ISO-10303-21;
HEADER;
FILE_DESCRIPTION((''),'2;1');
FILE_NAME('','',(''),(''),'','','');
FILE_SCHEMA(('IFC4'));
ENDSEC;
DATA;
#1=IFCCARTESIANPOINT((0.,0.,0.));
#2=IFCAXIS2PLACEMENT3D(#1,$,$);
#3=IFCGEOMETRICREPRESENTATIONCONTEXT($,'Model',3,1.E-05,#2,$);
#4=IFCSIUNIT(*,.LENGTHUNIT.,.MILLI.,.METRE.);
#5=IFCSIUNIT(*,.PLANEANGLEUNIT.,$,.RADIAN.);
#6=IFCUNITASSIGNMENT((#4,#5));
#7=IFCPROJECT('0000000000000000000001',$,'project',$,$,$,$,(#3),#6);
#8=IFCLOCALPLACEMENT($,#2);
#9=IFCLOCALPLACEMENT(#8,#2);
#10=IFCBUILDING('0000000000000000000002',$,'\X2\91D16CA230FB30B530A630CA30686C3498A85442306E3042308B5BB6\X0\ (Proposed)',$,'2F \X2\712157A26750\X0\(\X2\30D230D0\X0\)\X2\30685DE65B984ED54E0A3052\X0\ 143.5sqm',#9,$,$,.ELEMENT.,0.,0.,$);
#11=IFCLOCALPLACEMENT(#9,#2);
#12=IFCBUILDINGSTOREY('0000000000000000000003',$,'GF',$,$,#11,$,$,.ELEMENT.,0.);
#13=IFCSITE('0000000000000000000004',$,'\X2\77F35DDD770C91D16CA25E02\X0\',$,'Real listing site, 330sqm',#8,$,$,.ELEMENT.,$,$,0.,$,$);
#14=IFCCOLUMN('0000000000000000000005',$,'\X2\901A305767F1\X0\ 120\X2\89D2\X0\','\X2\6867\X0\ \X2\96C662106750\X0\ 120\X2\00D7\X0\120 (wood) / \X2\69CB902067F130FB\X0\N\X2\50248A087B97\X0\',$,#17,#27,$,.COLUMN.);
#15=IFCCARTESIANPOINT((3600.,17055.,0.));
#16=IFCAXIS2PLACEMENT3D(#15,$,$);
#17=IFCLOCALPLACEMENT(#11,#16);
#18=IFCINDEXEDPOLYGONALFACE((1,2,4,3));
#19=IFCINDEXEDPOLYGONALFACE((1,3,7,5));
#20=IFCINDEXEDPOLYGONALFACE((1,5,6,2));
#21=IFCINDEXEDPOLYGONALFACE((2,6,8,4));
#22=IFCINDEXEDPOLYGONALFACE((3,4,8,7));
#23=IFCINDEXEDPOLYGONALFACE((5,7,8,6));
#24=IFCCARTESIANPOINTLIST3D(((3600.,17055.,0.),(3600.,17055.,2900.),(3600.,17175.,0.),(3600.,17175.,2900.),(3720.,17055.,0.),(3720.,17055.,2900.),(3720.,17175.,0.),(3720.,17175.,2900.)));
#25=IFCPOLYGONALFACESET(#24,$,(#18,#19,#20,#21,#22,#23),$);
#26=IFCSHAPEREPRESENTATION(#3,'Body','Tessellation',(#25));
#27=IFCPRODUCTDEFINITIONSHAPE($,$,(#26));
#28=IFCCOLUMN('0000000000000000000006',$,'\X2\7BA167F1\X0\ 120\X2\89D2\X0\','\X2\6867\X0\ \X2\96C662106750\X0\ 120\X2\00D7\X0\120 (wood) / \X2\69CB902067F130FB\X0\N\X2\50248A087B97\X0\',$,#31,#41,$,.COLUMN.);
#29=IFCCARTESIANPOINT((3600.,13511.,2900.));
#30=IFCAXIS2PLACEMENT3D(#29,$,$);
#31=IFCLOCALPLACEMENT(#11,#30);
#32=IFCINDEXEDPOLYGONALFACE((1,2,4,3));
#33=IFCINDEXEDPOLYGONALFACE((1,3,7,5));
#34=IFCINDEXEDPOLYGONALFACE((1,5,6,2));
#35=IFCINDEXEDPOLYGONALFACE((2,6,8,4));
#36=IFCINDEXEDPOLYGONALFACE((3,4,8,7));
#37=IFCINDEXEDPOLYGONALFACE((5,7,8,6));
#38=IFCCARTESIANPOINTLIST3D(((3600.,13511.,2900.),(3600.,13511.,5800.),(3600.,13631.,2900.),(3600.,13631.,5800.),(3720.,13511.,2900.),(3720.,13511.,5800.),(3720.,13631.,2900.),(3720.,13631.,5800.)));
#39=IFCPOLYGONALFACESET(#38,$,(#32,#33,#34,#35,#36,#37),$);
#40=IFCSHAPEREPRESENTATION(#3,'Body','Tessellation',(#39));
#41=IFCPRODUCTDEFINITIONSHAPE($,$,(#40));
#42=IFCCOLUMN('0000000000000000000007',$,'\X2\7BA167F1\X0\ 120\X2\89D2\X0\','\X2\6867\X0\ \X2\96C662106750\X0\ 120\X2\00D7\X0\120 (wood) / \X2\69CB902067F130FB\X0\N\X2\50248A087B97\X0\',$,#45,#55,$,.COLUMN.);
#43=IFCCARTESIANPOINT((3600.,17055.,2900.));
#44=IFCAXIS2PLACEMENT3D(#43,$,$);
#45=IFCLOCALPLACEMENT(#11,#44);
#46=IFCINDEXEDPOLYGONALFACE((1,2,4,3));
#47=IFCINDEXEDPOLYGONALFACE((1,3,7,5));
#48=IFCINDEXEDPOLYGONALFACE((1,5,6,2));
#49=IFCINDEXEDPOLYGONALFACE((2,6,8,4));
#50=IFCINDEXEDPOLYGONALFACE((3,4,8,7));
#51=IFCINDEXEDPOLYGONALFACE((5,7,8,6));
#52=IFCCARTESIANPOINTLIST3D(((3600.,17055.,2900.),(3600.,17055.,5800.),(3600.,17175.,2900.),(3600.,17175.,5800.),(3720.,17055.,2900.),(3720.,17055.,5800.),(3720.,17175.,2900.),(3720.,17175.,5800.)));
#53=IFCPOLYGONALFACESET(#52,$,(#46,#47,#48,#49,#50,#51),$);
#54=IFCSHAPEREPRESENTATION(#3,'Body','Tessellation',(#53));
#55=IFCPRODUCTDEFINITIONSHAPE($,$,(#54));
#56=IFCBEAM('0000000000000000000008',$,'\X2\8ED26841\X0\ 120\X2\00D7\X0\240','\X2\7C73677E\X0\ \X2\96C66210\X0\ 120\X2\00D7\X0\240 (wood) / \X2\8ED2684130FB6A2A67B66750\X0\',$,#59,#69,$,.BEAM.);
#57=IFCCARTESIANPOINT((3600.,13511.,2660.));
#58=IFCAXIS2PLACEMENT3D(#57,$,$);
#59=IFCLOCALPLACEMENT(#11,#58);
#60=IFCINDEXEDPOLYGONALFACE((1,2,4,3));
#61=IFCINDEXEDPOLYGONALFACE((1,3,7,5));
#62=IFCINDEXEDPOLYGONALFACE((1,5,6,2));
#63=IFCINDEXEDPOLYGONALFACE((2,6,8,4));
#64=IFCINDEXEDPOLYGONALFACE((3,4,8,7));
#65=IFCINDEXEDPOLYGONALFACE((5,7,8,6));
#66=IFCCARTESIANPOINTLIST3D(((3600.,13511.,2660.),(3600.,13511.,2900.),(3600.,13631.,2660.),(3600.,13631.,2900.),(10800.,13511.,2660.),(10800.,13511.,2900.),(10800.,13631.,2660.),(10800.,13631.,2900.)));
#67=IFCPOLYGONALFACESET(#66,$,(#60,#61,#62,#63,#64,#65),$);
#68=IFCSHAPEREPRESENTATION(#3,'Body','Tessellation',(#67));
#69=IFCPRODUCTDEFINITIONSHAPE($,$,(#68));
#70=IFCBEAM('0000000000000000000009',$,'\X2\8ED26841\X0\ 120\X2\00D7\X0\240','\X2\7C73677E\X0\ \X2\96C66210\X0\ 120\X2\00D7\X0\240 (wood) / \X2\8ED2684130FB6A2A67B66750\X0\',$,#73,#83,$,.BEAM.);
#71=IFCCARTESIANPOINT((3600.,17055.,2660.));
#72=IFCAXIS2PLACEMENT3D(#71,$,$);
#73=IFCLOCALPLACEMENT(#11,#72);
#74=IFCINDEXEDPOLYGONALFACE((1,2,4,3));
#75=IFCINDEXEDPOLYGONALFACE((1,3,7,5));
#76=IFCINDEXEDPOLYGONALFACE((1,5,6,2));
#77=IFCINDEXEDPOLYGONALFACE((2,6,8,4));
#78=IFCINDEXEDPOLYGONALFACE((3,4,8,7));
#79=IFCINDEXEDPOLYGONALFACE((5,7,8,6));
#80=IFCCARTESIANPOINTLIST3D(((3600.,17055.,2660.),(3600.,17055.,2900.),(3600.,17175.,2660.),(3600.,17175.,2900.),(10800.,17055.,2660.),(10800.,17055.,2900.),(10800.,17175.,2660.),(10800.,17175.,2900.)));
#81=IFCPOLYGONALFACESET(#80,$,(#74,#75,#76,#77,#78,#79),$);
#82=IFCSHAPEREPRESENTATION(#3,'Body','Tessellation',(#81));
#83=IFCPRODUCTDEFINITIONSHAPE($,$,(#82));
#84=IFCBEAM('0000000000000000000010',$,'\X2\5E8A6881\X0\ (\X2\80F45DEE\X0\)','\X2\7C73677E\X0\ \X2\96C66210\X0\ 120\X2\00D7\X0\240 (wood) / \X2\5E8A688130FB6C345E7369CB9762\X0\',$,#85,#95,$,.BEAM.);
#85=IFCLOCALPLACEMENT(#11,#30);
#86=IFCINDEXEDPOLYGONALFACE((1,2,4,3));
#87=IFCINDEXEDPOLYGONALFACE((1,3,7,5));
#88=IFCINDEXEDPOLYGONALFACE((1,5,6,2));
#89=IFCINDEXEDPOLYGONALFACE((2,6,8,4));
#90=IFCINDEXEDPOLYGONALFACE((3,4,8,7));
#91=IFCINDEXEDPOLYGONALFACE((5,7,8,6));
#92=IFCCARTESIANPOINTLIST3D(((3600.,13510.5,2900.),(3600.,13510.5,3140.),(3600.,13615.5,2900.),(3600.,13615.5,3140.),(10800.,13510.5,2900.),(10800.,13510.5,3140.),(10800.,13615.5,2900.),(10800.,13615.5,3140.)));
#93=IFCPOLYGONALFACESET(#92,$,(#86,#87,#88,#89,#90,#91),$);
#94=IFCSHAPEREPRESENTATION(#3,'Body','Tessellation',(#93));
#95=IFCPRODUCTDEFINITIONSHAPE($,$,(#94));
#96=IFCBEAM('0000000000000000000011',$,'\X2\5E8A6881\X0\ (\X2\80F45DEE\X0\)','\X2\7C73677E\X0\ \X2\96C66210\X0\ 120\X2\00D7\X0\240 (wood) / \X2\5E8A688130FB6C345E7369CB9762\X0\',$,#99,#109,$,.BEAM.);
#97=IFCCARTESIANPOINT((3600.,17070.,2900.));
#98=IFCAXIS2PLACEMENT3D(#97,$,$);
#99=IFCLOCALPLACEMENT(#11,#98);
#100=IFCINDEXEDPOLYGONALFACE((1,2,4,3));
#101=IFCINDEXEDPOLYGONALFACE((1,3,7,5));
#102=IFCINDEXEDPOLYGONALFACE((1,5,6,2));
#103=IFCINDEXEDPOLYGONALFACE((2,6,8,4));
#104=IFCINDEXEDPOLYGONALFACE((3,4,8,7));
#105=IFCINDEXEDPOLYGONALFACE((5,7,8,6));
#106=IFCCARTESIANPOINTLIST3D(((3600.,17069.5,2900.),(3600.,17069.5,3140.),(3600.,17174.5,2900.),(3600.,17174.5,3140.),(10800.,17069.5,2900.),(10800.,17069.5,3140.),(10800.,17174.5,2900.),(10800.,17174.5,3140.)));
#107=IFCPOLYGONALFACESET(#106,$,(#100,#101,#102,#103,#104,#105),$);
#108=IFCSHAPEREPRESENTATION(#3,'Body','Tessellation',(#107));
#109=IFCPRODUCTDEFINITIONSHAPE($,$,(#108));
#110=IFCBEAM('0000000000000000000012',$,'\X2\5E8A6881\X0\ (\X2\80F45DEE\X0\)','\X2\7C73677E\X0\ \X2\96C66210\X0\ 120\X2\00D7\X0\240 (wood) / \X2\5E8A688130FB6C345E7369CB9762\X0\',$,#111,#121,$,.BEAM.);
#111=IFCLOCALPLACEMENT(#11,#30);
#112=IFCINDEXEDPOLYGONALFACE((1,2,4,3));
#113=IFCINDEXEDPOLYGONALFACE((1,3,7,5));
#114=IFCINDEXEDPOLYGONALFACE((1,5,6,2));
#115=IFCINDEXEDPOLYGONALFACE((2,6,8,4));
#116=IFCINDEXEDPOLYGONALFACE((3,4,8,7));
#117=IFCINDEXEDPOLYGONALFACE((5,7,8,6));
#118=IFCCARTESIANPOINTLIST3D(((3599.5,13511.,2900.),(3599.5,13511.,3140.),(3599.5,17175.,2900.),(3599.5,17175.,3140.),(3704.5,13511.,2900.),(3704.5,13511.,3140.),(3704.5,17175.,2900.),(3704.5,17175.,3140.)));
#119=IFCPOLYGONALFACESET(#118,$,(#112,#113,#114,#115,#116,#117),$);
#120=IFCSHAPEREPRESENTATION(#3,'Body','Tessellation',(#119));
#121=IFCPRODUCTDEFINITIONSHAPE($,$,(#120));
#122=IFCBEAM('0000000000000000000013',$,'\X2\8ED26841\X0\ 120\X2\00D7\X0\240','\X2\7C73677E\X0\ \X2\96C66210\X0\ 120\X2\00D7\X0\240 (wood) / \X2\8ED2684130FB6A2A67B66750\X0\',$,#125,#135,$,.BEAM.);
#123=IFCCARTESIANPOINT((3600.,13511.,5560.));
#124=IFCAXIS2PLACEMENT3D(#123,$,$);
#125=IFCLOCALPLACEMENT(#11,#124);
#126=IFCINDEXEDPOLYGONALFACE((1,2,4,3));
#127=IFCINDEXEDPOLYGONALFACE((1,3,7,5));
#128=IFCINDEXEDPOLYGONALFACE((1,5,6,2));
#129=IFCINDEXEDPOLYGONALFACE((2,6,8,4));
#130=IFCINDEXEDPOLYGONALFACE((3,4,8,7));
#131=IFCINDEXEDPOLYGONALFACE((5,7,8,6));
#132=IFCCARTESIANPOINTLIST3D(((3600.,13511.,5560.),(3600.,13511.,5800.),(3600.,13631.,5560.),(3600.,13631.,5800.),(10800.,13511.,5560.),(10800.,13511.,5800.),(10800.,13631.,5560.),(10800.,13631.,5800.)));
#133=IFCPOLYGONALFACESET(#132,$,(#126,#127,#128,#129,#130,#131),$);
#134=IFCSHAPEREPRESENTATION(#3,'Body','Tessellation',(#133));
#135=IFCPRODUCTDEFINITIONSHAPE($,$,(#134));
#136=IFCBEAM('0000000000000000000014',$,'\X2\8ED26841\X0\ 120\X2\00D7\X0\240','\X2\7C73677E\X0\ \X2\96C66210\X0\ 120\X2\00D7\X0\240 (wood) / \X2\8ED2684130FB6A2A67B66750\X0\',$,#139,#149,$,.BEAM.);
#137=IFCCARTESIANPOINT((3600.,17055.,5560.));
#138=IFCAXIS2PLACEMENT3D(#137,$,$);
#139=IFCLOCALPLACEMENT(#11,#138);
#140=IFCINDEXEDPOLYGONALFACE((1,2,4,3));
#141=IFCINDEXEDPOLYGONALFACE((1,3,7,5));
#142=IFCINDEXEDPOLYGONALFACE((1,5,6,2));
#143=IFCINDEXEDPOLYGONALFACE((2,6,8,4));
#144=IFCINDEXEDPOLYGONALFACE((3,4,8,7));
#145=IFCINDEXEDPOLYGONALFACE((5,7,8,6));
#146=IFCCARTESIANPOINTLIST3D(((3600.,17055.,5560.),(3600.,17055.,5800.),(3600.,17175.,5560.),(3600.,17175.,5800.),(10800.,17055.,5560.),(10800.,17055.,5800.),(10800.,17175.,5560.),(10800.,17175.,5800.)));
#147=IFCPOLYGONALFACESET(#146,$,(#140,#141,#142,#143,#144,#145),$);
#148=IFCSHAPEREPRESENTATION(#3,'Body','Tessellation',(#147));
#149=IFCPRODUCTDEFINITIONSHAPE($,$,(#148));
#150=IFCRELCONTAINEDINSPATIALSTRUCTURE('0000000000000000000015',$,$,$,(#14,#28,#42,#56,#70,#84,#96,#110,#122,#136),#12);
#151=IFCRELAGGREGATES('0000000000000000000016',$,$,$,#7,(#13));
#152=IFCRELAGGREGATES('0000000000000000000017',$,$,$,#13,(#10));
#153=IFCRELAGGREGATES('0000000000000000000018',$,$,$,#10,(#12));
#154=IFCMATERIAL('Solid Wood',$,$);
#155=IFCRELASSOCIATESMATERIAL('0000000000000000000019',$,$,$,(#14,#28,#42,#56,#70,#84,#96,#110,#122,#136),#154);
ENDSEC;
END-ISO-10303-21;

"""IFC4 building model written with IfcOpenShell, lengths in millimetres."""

from ifc_helpers import new_model, si_unit, frame, frame_2d, origin, place, context, project, spatial, rectangle, extrude, material, element, save


model = new_model("IFC4")

# Units and contexts
model_context = context("Model", 3, precision=1e-05, world=origin())
ifc_project = project(units=[si_unit("LENGTHUNIT", "METRE", prefix="MILLI"), si_unit("PLANEANGLEUNIT", "RADIAN")], contexts=[model_context])

# Site, building, storey
site_placement = place(None, origin())
site = spatial("IfcSite", under=ifc_project, at=site_placement, Name="石川県金沢市", ObjectType="Real listing site, 330sqm", CompositionType="ELEMENT", RefElevation=0.0)
building_placement = place(site_placement, origin())
building = spatial("IfcBuilding", under=site, at=building_placement, Name="金沢・サウナと水風呂のある家 (Proposed)", ObjectType="2F 無垢材(ヒバ)と左官仕上げ 143.5sqm", CompositionType="ELEMENT", ElevationOfRefHeight=0.0, ElevationOfTerrain=0.0)
storey_placement = place(building_placement, origin())
storey = spatial("IfcBuildingStorey", under=building, at=storey_placement, Name="GF", CompositionType="ELEMENT", Elevation=0.0)

# Columns
ifc_material_1 = material(Name="Solid Wood")
column_1_placement = place(storey_placement, frame((3600.0, 17055.0, 0.0)))
element("IfcColumn", 1, at=column_1_placement, inside=storey, material=ifc_material_1, Name="通し柱 120角", Description="桧 集成材 120×120 (wood) / 構造柱・N値計算", PredefinedType="COLUMN", context=model_context, shape_type="SweptSolid", body=[
    extrude(rectangle(XDim=120.0, YDim=120.0, at=frame_2d((60.0, 60.0))), frame((3600.0, 17055.0, 0.0)), (0.0, 0.0, 1.0), 2900.0),
])
column_2_placement = place(storey_placement, frame((3600.0, 13511.0, 2900.0)))
element("IfcColumn", 2, at=column_2_placement, inside=storey, material=ifc_material_1, Name="管柱 120角", Description="桧 集成材 120×120 (wood) / 構造柱・N値計算", PredefinedType="COLUMN", context=model_context, shape_type="SweptSolid", body=[
    extrude(rectangle(XDim=120.0, YDim=120.0, at=frame_2d((60.0, 60.0))), frame((3600.0, 13511.0, 2900.0)), (0.0, 0.0, 1.0), 2900.0),
])
column_3_placement = place(storey_placement, frame((3600.0, 17055.0, 2900.0)))
element("IfcColumn", 3, at=column_3_placement, inside=storey, material=ifc_material_1, Name="管柱 120角", Description="桧 集成材 120×120 (wood) / 構造柱・N値計算", PredefinedType="COLUMN", context=model_context, shape_type="SweptSolid", body=[
    extrude(rectangle(XDim=120.0, YDim=120.0, at=frame_2d((60.0, 60.0))), frame((3600.0, 17055.0, 2900.0)), (0.0, 0.0, 1.0), 2900.0),
])

# Beams
beam_1_placement = place(storey_placement, frame((3600.0, 13511.0, 2660.0)))
element("IfcBeam", 4, at=beam_1_placement, inside=storey, material=ifc_material_1, Name="軒桁 120×240", Description="米松 集成 120×240 (wood) / 軒桁・横架材", PredefinedType="BEAM", context=model_context, shape_type="SweptSolid", body=[
    extrude(rectangle(XDim=7200.0, YDim=120.0, at=frame_2d((3600.0, 60.0))), frame((3600.0, 13511.0, 2660.0)), (0.0, 0.0, 1.0), 240.0),
])
beam_2_placement = place(storey_placement, frame((3600.0, 17055.0, 2660.0)))
element("IfcBeam", 5, at=beam_2_placement, inside=storey, material=ifc_material_1, Name="軒桁 120×240", Description="米松 集成 120×240 (wood) / 軒桁・横架材", PredefinedType="BEAM", context=model_context, shape_type="SweptSolid", body=[
    extrude(rectangle(XDim=7200.0, YDim=120.0, at=frame_2d((3600.0, 60.0))), frame((3600.0, 17055.0, 2660.0)), (0.0, 0.0, 1.0), 240.0),
])
beam_3_placement = place(storey_placement, frame((3600.0, 13511.0, 2900.0)))
element("IfcBeam", 6, at=beam_3_placement, inside=storey, material=ifc_material_1, Name="床梁 (胴差)", Description="米松 集成 120×240 (wood) / 床梁・水平構面", PredefinedType="BEAM", context=model_context, shape_type="SweptSolid", body=[
    extrude(rectangle(XDim=7200.0, YDim=105.0, at=frame_2d((3600.0, 52.0))), frame((3600.0, 13511.0, 2900.0)), (0.0, 0.0, 1.0), 240.0),
])
beam_4_placement = place(storey_placement, frame((3600.0, 17070.0, 2900.0)))
element("IfcBeam", 7, at=beam_4_placement, inside=storey, material=ifc_material_1, Name="床梁 (胴差)", Description="米松 集成 120×240 (wood) / 床梁・水平構面", PredefinedType="BEAM", context=model_context, shape_type="SweptSolid", body=[
    extrude(rectangle(XDim=7200.0, YDim=105.0, at=frame_2d((3600.0, 52.0))), frame((3600.0, 17070.0, 2900.0)), (0.0, 0.0, 1.0), 240.0),
])
beam_5_placement = place(storey_placement, frame((3600.0, 13511.0, 2900.0)))
element("IfcBeam", 8, at=beam_5_placement, inside=storey, material=ifc_material_1, Name="床梁 (胴差)", Description="米松 集成 120×240 (wood) / 床梁・水平構面", PredefinedType="BEAM", context=model_context, shape_type="SweptSolid", body=[
    extrude(rectangle(XDim=105.0, YDim=3664.0, at=frame_2d((52.0, 1832.0))), frame((3600.0, 13511.0, 2900.0)), (0.0, 0.0, 1.0), 240.0),
])
beam_6_placement = place(storey_placement, frame((3600.0, 13511.0, 5560.0)))
element("IfcBeam", 9, at=beam_6_placement, inside=storey, material=ifc_material_1, Name="軒桁 120×240", Description="米松 集成 120×240 (wood) / 軒桁・横架材", PredefinedType="BEAM", context=model_context, shape_type="SweptSolid", body=[
    extrude(rectangle(XDim=7200.0, YDim=120.0, at=frame_2d((3600.0, 60.0))), frame((3600.0, 13511.0, 5560.0)), (0.0, 0.0, 1.0), 240.0),
])
beam_7_placement = place(storey_placement, frame((3600.0, 17055.0, 5560.0)))
element("IfcBeam", 10, at=beam_7_placement, inside=storey, material=ifc_material_1, Name="軒桁 120×240", Description="米松 集成 120×240 (wood) / 軒桁・横架材", PredefinedType="BEAM", context=model_context, shape_type="SweptSolid", body=[
    extrude(rectangle(XDim=7200.0, YDim=120.0, at=frame_2d((3600.0, 60.0))), frame((3600.0, 17055.0, 5560.0)), (0.0, 0.0, 1.0), 240.0),
])

save(model, "model.ifc")
